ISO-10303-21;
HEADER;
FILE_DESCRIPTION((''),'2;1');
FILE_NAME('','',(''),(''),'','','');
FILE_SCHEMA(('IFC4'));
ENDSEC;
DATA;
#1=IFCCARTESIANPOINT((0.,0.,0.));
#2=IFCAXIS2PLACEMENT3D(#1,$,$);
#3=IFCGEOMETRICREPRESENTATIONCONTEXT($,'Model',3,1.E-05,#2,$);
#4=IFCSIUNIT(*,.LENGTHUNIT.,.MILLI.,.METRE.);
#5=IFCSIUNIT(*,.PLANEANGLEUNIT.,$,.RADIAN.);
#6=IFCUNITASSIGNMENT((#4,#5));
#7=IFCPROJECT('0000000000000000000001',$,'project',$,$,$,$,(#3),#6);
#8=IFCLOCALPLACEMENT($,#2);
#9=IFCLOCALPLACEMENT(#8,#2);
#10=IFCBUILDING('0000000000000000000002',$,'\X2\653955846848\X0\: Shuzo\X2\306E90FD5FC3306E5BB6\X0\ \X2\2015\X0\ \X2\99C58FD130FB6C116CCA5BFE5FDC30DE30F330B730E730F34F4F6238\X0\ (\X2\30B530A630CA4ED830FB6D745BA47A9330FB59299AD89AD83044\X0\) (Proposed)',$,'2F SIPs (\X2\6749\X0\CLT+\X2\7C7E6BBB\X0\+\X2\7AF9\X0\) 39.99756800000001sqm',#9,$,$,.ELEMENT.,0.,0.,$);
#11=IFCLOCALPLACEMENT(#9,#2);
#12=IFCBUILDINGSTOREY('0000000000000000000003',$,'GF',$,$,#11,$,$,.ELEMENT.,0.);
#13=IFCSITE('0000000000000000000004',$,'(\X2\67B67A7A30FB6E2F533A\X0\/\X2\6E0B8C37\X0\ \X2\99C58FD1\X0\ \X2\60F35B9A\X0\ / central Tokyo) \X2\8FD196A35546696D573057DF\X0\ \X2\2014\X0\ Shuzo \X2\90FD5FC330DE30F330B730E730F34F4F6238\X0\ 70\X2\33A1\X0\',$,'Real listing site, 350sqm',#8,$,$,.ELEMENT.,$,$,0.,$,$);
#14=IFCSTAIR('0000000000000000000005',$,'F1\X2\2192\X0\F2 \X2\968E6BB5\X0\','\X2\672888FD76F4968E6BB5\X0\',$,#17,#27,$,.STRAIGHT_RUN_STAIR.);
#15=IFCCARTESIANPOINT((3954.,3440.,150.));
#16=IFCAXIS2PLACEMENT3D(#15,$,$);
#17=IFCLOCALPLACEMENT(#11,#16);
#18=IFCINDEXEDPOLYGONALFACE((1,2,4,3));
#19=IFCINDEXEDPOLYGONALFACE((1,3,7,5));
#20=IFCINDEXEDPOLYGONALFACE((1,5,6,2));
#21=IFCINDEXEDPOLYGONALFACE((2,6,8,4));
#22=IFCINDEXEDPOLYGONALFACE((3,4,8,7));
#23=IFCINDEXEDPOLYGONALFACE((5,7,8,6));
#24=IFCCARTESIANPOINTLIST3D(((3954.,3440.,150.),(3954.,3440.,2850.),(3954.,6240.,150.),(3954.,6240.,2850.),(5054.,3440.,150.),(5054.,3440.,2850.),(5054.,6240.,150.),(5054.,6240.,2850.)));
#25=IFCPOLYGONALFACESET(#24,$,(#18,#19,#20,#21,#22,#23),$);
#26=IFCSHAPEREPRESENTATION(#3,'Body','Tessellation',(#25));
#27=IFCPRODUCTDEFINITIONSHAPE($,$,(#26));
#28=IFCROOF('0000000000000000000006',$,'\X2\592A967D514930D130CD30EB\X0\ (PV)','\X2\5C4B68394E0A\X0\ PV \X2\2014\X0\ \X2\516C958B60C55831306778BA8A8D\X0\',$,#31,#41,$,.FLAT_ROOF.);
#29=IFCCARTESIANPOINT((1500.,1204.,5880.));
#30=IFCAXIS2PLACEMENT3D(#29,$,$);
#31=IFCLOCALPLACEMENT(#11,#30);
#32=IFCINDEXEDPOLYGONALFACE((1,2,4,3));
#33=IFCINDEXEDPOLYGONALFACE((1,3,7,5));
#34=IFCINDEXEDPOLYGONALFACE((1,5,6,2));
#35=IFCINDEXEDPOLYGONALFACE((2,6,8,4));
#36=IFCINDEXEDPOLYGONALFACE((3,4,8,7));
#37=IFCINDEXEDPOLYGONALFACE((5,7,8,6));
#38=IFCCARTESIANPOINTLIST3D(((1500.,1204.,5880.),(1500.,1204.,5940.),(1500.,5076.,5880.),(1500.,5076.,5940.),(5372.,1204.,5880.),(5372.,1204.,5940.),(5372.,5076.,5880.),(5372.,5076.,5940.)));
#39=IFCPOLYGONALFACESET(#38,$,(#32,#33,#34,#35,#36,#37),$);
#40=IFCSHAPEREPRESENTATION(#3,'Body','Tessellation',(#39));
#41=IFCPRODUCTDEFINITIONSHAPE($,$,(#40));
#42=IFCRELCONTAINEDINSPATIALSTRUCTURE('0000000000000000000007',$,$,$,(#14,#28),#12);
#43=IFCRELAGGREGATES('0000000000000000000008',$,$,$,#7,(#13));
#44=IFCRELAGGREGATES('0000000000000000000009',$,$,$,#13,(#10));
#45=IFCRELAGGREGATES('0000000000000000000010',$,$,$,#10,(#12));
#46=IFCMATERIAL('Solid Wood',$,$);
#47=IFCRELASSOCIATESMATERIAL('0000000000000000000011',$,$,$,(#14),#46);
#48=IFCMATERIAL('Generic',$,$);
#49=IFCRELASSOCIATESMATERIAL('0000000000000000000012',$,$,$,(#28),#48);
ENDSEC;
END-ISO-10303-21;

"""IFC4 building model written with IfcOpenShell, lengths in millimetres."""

from ifc_helpers import new_model, si_unit, frame, frame_2d, origin, place, context, project, spatial, rectangle, extrude, material, element, save


model = new_model("IFC4")

# Units and contexts
model_context = context("Model", 3, precision=1e-05, world=origin())
ifc_project = project(units=[si_unit("LENGTHUNIT", "METRE", prefix="MILLI"), si_unit("PLANEANGLEUNIT", "RADIAN")], contexts=[model_context])

# Site, building, storey
site_placement = place(None, origin())
site = spatial("IfcSite", under=ifc_project, at=site_placement, Name="(架空・港区/渋谷 駅近 想定 / central Tokyo) 近隣商業地域 — Shuzo 都心マンション住戸 70㎡", ObjectType="Real listing site, 350sqm", CompositionType="ELEMENT", RefElevation=0.0)
building_placement = place(site_placement, origin())
building = spatial("IfcBuilding", under=site, at=building_placement, Name="改善案: Shuzoの都心の家 ― 駅近・民泊対応マンション住戸 (サウナ付・浴室窓・天高高い) (Proposed)", ObjectType="2F SIPs (杉CLT+籾殻+竹) 39.99756800000001sqm", CompositionType="ELEMENT", ElevationOfRefHeight=0.0, ElevationOfTerrain=0.0)
storey_placement = place(building_placement, origin())
storey = spatial("IfcBuildingStorey", under=building, at=storey_placement, Name="GF", CompositionType="ELEMENT", Elevation=0.0)

# Shared definitions
ifc_material_1 = material(Name="Generic")

# Stair
ifc_material_2 = material(Name="Solid Wood")
stair_placement = place(storey_placement, frame((3954.0, 3440.0, 150.0)))
element("IfcStair", 1, at=stair_placement, inside=storey, material=ifc_material_2, Name="F1→F2 階段", Description="木製直階段", PredefinedType="STRAIGHT_RUN_STAIR", context=model_context, shape_type="SweptSolid", body=[
    extrude(rectangle(XDim=1100.0, YDim=2800.0, at=frame_2d((550.0, 1400.0))), frame((3954.0, 3440.0, 150.0)), (0.0, 0.0, 1.0), 2700.0),
])

# Roof
roof_placement = place(storey_placement, frame((1500.0, 1204.0, 5880.0)))
element("IfcRoof", 2, at=roof_placement, inside=storey, material=ifc_material_1, Name="太陽光パネル (PV)", Description="屋根上 PV — 公開情報で確認", PredefinedType="FLAT_ROOF", context=model_context, shape_type="SweptSolid", body=[
    extrude(rectangle(XDim=3872.0, YDim=3872.0, at=frame_2d((1936.0, 1936.0))), frame((1500.0, 1204.0, 5880.0)), (0.0, 0.0, 1.0), 60.0),
])

save(model, "model.ifc")
